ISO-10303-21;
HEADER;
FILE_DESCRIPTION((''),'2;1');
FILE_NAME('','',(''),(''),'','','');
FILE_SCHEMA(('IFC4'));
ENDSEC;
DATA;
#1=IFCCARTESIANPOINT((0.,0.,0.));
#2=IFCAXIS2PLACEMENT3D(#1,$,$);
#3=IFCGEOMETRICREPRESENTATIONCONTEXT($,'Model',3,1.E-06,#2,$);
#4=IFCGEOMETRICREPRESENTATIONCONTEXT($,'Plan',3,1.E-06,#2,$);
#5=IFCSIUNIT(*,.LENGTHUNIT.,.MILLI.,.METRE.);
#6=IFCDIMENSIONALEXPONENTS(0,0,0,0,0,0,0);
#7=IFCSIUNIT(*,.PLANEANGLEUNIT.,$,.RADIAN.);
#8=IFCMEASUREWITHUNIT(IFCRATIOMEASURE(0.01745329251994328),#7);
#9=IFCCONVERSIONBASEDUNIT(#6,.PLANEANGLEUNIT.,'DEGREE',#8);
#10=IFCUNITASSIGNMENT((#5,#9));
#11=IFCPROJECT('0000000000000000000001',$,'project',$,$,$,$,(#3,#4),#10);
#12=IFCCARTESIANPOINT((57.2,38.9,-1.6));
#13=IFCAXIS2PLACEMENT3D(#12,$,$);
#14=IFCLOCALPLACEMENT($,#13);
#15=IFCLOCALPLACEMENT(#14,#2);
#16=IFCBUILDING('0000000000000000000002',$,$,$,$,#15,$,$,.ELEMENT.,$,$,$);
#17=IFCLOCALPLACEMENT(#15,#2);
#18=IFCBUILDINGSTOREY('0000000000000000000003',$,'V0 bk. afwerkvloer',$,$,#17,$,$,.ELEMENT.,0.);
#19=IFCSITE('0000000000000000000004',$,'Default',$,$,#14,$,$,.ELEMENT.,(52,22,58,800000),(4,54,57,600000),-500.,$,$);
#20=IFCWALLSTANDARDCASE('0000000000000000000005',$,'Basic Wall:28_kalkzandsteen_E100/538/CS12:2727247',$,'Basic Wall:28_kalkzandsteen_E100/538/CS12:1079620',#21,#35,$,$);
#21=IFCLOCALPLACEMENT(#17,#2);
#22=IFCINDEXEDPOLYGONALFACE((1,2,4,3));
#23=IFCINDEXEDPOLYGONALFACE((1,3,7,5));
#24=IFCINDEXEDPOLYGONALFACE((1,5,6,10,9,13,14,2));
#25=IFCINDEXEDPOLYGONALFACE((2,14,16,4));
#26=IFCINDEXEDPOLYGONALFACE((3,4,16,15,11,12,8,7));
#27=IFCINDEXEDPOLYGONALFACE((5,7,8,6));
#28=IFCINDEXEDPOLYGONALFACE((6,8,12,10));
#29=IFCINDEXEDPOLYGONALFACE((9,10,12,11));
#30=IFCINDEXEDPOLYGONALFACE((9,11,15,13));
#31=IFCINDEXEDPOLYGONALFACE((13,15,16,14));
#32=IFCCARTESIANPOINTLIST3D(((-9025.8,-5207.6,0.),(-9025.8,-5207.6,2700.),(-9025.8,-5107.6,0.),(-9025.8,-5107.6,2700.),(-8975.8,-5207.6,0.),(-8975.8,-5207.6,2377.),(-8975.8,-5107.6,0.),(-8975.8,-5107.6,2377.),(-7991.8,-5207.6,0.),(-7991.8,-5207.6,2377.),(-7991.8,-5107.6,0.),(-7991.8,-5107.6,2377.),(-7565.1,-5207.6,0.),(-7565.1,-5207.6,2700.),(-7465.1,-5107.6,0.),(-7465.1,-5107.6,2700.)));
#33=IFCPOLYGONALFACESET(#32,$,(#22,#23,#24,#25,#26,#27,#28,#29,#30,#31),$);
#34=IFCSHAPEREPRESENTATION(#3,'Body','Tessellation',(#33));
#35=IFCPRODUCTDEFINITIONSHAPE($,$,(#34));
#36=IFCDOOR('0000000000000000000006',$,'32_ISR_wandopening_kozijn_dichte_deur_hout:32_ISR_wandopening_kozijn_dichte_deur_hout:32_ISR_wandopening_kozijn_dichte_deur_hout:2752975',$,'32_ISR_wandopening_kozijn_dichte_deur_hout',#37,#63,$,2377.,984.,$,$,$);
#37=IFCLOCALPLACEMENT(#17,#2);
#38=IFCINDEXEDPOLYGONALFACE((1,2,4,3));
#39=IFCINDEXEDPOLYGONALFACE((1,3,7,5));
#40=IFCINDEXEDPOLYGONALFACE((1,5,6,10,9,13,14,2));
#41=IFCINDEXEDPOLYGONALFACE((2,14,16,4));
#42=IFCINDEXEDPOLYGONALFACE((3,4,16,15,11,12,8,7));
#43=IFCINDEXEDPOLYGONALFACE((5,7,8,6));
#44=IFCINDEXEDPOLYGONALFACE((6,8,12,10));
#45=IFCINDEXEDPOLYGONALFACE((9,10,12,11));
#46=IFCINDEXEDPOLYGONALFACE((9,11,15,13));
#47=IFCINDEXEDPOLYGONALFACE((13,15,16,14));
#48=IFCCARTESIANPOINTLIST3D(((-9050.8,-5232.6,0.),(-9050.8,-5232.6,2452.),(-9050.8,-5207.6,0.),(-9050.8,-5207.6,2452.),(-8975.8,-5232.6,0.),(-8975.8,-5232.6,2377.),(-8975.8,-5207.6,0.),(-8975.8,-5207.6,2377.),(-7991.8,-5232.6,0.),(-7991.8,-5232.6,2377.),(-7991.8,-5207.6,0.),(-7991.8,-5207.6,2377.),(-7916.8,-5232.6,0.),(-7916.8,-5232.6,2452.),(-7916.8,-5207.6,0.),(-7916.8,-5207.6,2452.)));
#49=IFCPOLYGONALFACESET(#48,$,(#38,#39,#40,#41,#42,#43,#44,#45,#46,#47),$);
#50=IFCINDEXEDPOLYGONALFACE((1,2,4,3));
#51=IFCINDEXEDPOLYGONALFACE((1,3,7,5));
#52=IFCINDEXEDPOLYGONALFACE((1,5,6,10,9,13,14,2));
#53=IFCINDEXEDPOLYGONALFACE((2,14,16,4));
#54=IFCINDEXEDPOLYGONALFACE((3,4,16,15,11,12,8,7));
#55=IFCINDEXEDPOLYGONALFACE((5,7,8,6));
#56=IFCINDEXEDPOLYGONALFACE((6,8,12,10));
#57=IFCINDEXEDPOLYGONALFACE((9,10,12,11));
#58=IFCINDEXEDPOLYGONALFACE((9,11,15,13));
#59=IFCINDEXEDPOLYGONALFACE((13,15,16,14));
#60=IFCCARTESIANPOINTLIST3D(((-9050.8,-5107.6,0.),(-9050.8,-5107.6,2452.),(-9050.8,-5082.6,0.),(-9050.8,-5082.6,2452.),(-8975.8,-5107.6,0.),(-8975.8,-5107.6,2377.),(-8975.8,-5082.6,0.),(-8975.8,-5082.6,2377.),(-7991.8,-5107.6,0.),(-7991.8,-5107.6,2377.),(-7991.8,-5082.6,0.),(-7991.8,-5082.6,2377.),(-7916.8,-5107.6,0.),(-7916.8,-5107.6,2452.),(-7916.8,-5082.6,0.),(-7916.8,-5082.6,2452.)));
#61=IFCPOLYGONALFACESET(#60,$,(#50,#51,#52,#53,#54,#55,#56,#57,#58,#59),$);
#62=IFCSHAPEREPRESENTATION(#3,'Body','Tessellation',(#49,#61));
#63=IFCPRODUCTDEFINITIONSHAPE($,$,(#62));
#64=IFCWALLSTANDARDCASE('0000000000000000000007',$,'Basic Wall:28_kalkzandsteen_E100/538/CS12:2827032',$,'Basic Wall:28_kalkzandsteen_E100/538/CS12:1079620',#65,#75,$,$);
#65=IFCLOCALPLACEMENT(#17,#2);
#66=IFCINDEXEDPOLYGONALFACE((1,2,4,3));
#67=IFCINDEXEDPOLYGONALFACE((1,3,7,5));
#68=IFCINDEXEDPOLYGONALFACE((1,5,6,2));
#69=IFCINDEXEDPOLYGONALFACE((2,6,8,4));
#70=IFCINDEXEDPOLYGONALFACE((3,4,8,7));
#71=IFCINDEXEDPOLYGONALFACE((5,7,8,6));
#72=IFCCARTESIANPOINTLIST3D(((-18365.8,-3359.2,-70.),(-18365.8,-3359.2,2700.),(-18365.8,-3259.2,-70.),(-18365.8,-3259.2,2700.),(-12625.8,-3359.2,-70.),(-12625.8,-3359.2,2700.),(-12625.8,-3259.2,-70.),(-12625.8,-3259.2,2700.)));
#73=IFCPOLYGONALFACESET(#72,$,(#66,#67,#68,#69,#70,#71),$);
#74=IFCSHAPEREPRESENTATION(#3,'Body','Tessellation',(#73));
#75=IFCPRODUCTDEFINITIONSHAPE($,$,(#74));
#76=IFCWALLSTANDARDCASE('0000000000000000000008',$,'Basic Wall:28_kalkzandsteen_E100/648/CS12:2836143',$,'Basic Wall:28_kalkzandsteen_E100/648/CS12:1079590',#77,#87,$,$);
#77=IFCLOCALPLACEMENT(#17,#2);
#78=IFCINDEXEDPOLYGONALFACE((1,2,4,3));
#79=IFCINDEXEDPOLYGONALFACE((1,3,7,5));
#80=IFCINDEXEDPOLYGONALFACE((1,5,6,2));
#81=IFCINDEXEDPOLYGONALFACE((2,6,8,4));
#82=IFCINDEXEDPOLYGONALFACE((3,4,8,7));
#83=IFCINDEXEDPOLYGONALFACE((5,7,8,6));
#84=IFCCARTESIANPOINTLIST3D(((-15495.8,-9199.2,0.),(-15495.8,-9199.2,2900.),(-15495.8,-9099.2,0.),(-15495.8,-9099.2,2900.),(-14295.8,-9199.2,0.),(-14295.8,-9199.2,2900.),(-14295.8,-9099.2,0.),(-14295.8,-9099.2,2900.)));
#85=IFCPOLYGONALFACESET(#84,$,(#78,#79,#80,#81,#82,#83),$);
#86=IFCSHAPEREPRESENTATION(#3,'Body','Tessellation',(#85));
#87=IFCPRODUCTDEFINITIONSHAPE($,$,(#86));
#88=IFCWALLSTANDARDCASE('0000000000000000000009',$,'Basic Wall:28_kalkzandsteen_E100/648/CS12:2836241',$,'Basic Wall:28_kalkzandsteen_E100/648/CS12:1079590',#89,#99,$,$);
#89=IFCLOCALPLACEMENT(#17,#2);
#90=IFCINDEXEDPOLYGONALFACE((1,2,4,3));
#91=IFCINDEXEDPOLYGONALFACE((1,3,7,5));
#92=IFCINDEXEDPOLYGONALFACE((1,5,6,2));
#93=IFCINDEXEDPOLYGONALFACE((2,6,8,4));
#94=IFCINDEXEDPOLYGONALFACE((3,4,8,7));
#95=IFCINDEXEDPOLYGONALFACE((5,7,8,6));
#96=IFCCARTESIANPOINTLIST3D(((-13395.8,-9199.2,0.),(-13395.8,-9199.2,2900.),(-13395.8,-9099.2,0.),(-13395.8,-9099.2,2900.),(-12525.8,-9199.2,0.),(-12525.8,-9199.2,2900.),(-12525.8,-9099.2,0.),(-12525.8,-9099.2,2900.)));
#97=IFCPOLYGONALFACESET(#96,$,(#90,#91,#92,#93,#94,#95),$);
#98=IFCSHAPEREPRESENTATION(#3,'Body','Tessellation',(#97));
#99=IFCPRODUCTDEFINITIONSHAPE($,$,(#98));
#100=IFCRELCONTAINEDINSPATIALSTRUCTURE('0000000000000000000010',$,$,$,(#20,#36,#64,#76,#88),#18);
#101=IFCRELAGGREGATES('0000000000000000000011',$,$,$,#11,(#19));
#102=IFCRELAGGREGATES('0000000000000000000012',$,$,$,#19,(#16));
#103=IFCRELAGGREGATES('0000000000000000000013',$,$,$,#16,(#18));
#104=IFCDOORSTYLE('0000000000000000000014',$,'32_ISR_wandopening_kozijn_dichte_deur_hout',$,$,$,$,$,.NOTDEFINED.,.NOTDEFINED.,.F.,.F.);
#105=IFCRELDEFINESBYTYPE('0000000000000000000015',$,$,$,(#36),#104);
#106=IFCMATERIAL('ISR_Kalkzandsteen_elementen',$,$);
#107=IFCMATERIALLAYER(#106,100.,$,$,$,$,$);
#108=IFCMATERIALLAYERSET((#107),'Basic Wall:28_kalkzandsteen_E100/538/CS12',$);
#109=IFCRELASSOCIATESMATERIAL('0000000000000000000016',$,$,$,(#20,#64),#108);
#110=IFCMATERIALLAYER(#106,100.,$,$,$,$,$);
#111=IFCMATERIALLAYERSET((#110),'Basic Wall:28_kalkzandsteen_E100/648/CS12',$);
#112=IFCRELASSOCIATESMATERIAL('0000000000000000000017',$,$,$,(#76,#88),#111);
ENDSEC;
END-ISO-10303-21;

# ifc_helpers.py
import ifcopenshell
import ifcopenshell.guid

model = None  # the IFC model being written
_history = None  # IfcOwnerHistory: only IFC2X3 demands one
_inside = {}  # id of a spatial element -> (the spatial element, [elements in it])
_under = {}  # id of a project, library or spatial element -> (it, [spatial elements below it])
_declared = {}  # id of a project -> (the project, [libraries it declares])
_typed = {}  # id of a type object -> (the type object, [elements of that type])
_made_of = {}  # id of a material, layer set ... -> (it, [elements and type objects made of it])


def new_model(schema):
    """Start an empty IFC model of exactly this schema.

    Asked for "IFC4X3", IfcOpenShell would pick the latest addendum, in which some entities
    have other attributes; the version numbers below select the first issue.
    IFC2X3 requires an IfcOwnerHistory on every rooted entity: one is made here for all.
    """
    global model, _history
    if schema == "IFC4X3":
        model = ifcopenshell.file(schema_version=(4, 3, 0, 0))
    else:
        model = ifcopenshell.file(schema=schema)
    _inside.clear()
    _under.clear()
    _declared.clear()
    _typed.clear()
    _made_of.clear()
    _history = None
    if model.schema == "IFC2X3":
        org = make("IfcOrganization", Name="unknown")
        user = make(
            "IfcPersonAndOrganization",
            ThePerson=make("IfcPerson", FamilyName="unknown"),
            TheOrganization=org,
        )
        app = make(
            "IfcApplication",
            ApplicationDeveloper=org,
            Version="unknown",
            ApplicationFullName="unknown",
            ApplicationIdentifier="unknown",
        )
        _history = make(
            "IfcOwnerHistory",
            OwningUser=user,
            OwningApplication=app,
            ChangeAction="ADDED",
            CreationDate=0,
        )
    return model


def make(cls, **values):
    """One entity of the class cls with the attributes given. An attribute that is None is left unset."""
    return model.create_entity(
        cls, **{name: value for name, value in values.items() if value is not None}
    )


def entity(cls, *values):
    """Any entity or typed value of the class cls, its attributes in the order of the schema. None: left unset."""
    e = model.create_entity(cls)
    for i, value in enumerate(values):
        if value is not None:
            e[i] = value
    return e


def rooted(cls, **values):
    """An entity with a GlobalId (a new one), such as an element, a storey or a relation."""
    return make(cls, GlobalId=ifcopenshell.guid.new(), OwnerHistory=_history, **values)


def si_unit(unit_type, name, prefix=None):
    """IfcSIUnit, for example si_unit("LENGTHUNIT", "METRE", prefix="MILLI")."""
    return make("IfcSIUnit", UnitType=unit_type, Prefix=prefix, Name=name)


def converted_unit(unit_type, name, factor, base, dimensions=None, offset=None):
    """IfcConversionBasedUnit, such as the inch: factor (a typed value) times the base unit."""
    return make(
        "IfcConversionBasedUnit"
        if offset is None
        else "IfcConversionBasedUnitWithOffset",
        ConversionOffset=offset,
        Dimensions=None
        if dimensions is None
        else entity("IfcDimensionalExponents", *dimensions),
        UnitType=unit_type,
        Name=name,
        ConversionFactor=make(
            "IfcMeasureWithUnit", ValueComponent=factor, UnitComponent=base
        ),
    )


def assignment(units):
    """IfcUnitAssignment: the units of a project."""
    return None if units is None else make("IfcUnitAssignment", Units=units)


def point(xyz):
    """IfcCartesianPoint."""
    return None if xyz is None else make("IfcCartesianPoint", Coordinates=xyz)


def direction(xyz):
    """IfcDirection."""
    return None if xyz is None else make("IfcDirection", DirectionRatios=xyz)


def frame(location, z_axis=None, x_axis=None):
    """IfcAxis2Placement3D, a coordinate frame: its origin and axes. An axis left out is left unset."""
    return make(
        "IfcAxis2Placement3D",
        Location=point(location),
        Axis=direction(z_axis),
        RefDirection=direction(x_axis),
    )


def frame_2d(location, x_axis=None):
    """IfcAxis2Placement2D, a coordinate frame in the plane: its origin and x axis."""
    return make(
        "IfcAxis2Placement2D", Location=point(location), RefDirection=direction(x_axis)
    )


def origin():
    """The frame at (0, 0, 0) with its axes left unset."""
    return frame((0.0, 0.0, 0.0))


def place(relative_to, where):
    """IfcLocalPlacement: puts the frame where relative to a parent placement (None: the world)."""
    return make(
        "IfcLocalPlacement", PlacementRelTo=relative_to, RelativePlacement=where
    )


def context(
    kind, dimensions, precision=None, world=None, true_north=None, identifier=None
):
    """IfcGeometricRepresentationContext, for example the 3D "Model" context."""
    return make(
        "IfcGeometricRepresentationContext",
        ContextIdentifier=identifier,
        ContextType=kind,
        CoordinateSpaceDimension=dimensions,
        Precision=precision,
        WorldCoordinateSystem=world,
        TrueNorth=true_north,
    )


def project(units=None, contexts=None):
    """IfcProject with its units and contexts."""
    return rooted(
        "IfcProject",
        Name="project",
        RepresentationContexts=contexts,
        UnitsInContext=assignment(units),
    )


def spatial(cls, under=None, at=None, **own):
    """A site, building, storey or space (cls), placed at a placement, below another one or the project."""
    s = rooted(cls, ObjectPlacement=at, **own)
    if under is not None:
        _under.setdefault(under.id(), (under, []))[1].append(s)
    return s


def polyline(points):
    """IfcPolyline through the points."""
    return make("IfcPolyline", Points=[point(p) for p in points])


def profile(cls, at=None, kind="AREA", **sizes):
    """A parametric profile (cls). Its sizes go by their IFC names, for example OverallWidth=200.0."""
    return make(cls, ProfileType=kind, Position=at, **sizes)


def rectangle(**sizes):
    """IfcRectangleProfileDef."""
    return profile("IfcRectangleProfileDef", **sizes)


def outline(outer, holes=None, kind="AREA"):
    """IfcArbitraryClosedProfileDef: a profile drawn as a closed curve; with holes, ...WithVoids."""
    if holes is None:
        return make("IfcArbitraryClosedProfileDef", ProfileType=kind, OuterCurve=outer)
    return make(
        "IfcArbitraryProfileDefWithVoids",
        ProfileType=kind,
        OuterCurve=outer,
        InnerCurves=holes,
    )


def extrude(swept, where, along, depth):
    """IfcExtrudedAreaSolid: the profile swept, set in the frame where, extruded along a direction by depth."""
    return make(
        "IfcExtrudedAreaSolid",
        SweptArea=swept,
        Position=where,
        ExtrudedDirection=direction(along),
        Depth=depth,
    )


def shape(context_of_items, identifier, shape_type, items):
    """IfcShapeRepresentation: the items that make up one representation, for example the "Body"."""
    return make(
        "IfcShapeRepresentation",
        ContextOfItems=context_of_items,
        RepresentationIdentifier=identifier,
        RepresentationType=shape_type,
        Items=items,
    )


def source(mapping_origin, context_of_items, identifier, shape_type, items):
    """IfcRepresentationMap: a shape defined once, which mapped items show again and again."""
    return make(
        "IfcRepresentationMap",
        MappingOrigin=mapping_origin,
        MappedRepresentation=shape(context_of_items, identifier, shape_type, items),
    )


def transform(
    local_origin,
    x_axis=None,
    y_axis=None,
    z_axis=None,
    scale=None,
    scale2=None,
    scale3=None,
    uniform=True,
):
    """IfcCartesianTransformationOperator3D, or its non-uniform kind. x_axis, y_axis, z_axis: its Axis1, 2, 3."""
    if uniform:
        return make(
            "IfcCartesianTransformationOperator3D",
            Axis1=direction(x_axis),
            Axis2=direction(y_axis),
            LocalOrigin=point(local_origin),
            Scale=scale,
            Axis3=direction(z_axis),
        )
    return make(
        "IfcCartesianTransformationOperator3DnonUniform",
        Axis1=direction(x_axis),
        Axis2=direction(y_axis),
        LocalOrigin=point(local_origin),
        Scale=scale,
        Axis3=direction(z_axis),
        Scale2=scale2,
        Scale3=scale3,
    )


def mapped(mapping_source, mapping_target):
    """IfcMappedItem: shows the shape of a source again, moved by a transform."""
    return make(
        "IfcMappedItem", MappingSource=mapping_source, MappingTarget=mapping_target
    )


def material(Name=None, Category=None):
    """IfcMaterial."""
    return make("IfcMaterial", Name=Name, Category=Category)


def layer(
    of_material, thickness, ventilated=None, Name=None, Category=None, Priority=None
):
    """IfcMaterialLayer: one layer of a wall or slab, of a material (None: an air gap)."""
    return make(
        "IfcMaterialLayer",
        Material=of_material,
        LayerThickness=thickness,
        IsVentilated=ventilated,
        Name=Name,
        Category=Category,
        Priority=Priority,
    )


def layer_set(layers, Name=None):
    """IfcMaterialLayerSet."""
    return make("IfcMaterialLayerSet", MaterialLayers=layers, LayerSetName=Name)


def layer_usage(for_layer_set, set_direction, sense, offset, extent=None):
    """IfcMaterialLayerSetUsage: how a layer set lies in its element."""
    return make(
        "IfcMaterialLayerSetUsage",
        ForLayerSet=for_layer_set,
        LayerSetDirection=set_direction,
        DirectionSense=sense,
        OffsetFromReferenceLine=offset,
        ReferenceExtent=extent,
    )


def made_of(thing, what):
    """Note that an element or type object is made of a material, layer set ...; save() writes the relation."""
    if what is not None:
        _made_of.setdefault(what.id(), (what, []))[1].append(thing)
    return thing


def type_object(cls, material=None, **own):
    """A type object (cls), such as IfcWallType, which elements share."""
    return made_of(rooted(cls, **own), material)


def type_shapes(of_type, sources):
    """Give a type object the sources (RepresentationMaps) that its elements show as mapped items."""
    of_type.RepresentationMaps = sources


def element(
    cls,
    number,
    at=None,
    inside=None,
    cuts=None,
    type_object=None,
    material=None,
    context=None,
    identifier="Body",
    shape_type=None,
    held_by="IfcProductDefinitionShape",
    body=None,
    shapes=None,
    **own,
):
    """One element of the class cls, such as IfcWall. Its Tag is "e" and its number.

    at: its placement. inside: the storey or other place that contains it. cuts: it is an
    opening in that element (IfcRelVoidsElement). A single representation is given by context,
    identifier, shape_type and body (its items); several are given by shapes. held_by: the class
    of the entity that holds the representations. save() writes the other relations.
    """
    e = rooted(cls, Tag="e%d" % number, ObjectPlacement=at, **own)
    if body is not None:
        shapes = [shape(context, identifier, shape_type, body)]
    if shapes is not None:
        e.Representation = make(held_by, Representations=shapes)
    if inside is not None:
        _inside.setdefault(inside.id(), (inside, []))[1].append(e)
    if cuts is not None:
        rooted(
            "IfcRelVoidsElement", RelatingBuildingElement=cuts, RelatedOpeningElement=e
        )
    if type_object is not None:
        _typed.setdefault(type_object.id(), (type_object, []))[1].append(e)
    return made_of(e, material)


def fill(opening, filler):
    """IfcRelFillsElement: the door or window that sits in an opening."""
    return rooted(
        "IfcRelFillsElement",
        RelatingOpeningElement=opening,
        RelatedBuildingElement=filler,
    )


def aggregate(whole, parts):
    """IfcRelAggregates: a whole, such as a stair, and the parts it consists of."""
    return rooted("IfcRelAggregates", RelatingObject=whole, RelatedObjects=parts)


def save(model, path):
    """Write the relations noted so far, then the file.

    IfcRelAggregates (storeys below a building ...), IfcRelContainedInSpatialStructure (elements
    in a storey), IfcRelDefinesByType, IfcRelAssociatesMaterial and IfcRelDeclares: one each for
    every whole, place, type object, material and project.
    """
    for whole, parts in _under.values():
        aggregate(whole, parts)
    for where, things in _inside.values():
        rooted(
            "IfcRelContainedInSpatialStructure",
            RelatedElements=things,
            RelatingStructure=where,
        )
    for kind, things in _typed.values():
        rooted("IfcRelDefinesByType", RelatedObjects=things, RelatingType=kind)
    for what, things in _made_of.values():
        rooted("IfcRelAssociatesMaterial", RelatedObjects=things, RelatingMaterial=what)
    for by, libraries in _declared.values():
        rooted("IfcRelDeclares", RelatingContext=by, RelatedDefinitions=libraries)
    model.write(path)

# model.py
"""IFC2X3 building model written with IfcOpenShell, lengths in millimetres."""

from ifc_helpers import new_model, entity, si_unit, converted_unit, frame, frame_2d, origin, place, context, project, spatial, polyline, rectangle, outline, extrude, source, transform, mapped, material, layer, layer_set, layer_usage, type_object, type_shapes, element, fill, save


model = new_model("IFC2X3")

# Units and contexts
model_context = context("Model", 3, precision=1e-06, world=origin())
plan_context = context("Plan", 3, precision=1e-06, world=origin())
ifc_project = project(units=[si_unit("LENGTHUNIT", "METRE", prefix="MILLI"), converted_unit("PLANEANGLEUNIT", "DEGREE", entity("IfcRatioMeasure", 0.01745329251994328), si_unit("PLANEANGLEUNIT", "RADIAN"), dimensions=[0, 0, 0, 0, 0, 0, 0])], contexts=[model_context, plan_context])

# Site, building, storey
site_placement = place(None, frame((57.2, 38.9, -1.6)))
site = spatial("IfcSite", under=ifc_project, at=site_placement, Name="Default", CompositionType="ELEMENT", RefLatitude=(52, 22, 58, 800000), RefLongitude=(4, 54, 57, 600000), RefElevation=-500.0)
building_placement = place(site_placement, origin())
building = spatial("IfcBuilding", under=site, at=building_placement, CompositionType="ELEMENT")
storey_placement = place(building_placement, origin())
storey = spatial("IfcBuildingStorey", under=building, at=storey_placement, Name="V0 bk. afwerkvloer", CompositionType="ELEMENT", Elevation=0.0)

# Shared definitions
ifc_material = material(Name="ISR_Kalkzandsteen_elementen")
ifc_layer_1 = layer(ifc_material, 100.0)
ifc_layer_set_1 = layer_set([ifc_layer_1], Name="Basic Wall:28_kalkzandsteen_E100/538/CS12")

# Wall, opening, door
ifc_layer_usage_1 = layer_usage(ifc_layer_set_1, "AXIS2", "NEGATIVE", 50.0)
wall_1_placement = place(storey_placement, frame((-9025.8, -5157.6, 0.0)))
wall_1 = element("IfcWallStandardCase", 1, at=wall_1_placement, inside=storey, material=ifc_layer_usage_1, Name="Basic Wall:28_kalkzandsteen_E100/538/CS12:2727247", ObjectType="Basic Wall:28_kalkzandsteen_E100/538/CS12:1079620", context=model_context, shape_type="SweptSolid", body=[
    extrude(outline(polyline([(0.0, -50.0), (1460.7, -50.0), (1560.7, 50.0), (1419.3, 50.0), (0.0, 50.0), (0.0, -50.0)])), origin(), (0.0, 0.0, 1.0), 2700.0),
])
opening_1_placement = place(wall_1_placement, frame((1034.0, 50.0, 0.0)))
opening_1 = element("IfcOpeningElement", 2, at=opening_1_placement, cuts=wall_1, ObjectType="Opening", context=model_context, shape_type="SweptSolid", body=[
    extrude(rectangle(XDim=2377.0, YDim=984.0, at=frame_2d((1188.5, 492.0), x_axis=(1.0, 0.0))), frame((0.0, 0.0, 0.0), z_axis=(0.0, -1.0, 0.0), x_axis=(0.0, 0.0, 1.0)), (0.0, 0.0, 1.0), 100.0),
])
door_style_1 = type_object("IfcDoorStyle", Name="32_ISR_wandopening_kozijn_dichte_deur_hout", ConstructionType="NOTDEFINED", OperationType="NOTDEFINED", ParameterTakesPrecedence=False, Sizeable=False)
shared_shape_1 = source(origin(), model_context, "Body", "SweptSolid", [
    extrude(outline(polyline([(-1169.7, 492.0), (1207.2, 492.0), (1207.2, 567.0), (-1244.7, 567.0), (-1244.7, -567.0), (1207.2, -567.0), (1207.2, -492.0), (-1169.7, -492.0), (-1169.7, 492.0)])), frame((1202.0, 125.0, 1207.2), z_axis=(0.0, -1.0, 0.0), x_axis=(0.0, 0.0, -1.0)), (0.0, 0.0, 1.0), 25.0),
    extrude(outline(polyline([(-567.0, -1244.7), (567.0, -1244.7), (567.0, 1207.2), (492.0, 1207.2), (492.0, -1169.7), (-492.0, -1169.7), (-492.0, 1207.2), (-567.0, 1207.2), (-567.0, -1244.7)])), frame((1202.0, 0.0, 1207.2), z_axis=(0.0, -1.0, 0.0), x_axis=(-1.0, 0.0, 0.0)), (0.0, 0.0, 1.0), 25.0),
])
type_shapes(door_style_1, [shared_shape_1])
door_1_placement = place(opening_1_placement, frame((710.0, 0.0, 0.0), z_axis=(0.0, 0.0, 1.0), x_axis=(-1.0, 0.0, 0.0)))
door_1 = element("IfcDoor", 3, at=door_1_placement, inside=storey, type_object=door_style_1, Name="32_ISR_wandopening_kozijn_dichte_deur_hout:32_ISR_wandopening_kozijn_dichte_deur_hout:32_ISR_wandopening_kozijn_dichte_deur_hout:2752975", ObjectType="32_ISR_wandopening_kozijn_dichte_deur_hout", OverallHeight=2377.0, OverallWidth=984.0, context=model_context, shape_type="MappedRepresentation", body=[
    mapped(shared_shape_1, transform((0.0, 0.0, 0.0), scale=1.0)),
])
fill(opening_1, door_1)

# Walls
ifc_layer_usage_2 = layer_usage(ifc_layer_set_1, "AXIS2", "POSITIVE", -50.0)
wall_2_placement = place(storey_placement, frame((-12625.8, -3309.2, -70.0), z_axis=(0.0, 0.0, 1.0), x_axis=(-1.0, 0.0, 0.0)))
element("IfcWallStandardCase", 4, at=wall_2_placement, inside=storey, material=ifc_layer_usage_2, Name="Basic Wall:28_kalkzandsteen_E100/538/CS12:2827032", ObjectType="Basic Wall:28_kalkzandsteen_E100/538/CS12:1079620", context=model_context, shape_type="SweptSolid", body=[
    extrude(rectangle(XDim=5740.0, YDim=100.0, at=frame_2d((2870.0, 0.0), x_axis=(-1.0, 0.0))), origin(), (0.0, 0.0, 1.0), 2770.0),
])
ifc_layer_2 = layer(ifc_material, 100.0)
ifc_layer_set_2 = layer_set([ifc_layer_2], Name="Basic Wall:28_kalkzandsteen_E100/648/CS12")
ifc_layer_usage_3 = layer_usage(ifc_layer_set_2, "AXIS2", "POSITIVE", -50.0)
wall_3_placement = place(storey_placement, frame((-15495.8, -9149.2, 0.0)))
element("IfcWallStandardCase", 5, at=wall_3_placement, inside=storey, material=ifc_layer_usage_3, Name="Basic Wall:28_kalkzandsteen_E100/648/CS12:2836143", ObjectType="Basic Wall:28_kalkzandsteen_E100/648/CS12:1079590", context=model_context, shape_type="SweptSolid", body=[
    extrude(rectangle(XDim=1200.0, YDim=100.0, at=frame_2d((600.0, 0.0), x_axis=(-1.0, 0.0))), origin(), (0.0, 0.0, 1.0), 2900.0),
])
ifc_layer_usage_4 = layer_usage(ifc_layer_set_2, "AXIS2", "NEGATIVE", 50.0)
wall_4_placement = place(storey_placement, frame((-12525.8, -9149.2, 0.0), z_axis=(0.0, 0.0, 1.0), x_axis=(-1.0, 0.0, 0.0)))
element("IfcWallStandardCase", 6, at=wall_4_placement, inside=storey, material=ifc_layer_usage_4, Name="Basic Wall:28_kalkzandsteen_E100/648/CS12:2836241", ObjectType="Basic Wall:28_kalkzandsteen_E100/648/CS12:1079590", context=model_context, shape_type="SweptSolid", body=[
    extrude(rectangle(XDim=870.0, YDim=100.0, at=frame_2d((435.0, 0.0), x_axis=(-1.0, 0.0))), origin(), (0.0, 0.0, 1.0), 2900.0),
])

save(model, "model.ifc")
